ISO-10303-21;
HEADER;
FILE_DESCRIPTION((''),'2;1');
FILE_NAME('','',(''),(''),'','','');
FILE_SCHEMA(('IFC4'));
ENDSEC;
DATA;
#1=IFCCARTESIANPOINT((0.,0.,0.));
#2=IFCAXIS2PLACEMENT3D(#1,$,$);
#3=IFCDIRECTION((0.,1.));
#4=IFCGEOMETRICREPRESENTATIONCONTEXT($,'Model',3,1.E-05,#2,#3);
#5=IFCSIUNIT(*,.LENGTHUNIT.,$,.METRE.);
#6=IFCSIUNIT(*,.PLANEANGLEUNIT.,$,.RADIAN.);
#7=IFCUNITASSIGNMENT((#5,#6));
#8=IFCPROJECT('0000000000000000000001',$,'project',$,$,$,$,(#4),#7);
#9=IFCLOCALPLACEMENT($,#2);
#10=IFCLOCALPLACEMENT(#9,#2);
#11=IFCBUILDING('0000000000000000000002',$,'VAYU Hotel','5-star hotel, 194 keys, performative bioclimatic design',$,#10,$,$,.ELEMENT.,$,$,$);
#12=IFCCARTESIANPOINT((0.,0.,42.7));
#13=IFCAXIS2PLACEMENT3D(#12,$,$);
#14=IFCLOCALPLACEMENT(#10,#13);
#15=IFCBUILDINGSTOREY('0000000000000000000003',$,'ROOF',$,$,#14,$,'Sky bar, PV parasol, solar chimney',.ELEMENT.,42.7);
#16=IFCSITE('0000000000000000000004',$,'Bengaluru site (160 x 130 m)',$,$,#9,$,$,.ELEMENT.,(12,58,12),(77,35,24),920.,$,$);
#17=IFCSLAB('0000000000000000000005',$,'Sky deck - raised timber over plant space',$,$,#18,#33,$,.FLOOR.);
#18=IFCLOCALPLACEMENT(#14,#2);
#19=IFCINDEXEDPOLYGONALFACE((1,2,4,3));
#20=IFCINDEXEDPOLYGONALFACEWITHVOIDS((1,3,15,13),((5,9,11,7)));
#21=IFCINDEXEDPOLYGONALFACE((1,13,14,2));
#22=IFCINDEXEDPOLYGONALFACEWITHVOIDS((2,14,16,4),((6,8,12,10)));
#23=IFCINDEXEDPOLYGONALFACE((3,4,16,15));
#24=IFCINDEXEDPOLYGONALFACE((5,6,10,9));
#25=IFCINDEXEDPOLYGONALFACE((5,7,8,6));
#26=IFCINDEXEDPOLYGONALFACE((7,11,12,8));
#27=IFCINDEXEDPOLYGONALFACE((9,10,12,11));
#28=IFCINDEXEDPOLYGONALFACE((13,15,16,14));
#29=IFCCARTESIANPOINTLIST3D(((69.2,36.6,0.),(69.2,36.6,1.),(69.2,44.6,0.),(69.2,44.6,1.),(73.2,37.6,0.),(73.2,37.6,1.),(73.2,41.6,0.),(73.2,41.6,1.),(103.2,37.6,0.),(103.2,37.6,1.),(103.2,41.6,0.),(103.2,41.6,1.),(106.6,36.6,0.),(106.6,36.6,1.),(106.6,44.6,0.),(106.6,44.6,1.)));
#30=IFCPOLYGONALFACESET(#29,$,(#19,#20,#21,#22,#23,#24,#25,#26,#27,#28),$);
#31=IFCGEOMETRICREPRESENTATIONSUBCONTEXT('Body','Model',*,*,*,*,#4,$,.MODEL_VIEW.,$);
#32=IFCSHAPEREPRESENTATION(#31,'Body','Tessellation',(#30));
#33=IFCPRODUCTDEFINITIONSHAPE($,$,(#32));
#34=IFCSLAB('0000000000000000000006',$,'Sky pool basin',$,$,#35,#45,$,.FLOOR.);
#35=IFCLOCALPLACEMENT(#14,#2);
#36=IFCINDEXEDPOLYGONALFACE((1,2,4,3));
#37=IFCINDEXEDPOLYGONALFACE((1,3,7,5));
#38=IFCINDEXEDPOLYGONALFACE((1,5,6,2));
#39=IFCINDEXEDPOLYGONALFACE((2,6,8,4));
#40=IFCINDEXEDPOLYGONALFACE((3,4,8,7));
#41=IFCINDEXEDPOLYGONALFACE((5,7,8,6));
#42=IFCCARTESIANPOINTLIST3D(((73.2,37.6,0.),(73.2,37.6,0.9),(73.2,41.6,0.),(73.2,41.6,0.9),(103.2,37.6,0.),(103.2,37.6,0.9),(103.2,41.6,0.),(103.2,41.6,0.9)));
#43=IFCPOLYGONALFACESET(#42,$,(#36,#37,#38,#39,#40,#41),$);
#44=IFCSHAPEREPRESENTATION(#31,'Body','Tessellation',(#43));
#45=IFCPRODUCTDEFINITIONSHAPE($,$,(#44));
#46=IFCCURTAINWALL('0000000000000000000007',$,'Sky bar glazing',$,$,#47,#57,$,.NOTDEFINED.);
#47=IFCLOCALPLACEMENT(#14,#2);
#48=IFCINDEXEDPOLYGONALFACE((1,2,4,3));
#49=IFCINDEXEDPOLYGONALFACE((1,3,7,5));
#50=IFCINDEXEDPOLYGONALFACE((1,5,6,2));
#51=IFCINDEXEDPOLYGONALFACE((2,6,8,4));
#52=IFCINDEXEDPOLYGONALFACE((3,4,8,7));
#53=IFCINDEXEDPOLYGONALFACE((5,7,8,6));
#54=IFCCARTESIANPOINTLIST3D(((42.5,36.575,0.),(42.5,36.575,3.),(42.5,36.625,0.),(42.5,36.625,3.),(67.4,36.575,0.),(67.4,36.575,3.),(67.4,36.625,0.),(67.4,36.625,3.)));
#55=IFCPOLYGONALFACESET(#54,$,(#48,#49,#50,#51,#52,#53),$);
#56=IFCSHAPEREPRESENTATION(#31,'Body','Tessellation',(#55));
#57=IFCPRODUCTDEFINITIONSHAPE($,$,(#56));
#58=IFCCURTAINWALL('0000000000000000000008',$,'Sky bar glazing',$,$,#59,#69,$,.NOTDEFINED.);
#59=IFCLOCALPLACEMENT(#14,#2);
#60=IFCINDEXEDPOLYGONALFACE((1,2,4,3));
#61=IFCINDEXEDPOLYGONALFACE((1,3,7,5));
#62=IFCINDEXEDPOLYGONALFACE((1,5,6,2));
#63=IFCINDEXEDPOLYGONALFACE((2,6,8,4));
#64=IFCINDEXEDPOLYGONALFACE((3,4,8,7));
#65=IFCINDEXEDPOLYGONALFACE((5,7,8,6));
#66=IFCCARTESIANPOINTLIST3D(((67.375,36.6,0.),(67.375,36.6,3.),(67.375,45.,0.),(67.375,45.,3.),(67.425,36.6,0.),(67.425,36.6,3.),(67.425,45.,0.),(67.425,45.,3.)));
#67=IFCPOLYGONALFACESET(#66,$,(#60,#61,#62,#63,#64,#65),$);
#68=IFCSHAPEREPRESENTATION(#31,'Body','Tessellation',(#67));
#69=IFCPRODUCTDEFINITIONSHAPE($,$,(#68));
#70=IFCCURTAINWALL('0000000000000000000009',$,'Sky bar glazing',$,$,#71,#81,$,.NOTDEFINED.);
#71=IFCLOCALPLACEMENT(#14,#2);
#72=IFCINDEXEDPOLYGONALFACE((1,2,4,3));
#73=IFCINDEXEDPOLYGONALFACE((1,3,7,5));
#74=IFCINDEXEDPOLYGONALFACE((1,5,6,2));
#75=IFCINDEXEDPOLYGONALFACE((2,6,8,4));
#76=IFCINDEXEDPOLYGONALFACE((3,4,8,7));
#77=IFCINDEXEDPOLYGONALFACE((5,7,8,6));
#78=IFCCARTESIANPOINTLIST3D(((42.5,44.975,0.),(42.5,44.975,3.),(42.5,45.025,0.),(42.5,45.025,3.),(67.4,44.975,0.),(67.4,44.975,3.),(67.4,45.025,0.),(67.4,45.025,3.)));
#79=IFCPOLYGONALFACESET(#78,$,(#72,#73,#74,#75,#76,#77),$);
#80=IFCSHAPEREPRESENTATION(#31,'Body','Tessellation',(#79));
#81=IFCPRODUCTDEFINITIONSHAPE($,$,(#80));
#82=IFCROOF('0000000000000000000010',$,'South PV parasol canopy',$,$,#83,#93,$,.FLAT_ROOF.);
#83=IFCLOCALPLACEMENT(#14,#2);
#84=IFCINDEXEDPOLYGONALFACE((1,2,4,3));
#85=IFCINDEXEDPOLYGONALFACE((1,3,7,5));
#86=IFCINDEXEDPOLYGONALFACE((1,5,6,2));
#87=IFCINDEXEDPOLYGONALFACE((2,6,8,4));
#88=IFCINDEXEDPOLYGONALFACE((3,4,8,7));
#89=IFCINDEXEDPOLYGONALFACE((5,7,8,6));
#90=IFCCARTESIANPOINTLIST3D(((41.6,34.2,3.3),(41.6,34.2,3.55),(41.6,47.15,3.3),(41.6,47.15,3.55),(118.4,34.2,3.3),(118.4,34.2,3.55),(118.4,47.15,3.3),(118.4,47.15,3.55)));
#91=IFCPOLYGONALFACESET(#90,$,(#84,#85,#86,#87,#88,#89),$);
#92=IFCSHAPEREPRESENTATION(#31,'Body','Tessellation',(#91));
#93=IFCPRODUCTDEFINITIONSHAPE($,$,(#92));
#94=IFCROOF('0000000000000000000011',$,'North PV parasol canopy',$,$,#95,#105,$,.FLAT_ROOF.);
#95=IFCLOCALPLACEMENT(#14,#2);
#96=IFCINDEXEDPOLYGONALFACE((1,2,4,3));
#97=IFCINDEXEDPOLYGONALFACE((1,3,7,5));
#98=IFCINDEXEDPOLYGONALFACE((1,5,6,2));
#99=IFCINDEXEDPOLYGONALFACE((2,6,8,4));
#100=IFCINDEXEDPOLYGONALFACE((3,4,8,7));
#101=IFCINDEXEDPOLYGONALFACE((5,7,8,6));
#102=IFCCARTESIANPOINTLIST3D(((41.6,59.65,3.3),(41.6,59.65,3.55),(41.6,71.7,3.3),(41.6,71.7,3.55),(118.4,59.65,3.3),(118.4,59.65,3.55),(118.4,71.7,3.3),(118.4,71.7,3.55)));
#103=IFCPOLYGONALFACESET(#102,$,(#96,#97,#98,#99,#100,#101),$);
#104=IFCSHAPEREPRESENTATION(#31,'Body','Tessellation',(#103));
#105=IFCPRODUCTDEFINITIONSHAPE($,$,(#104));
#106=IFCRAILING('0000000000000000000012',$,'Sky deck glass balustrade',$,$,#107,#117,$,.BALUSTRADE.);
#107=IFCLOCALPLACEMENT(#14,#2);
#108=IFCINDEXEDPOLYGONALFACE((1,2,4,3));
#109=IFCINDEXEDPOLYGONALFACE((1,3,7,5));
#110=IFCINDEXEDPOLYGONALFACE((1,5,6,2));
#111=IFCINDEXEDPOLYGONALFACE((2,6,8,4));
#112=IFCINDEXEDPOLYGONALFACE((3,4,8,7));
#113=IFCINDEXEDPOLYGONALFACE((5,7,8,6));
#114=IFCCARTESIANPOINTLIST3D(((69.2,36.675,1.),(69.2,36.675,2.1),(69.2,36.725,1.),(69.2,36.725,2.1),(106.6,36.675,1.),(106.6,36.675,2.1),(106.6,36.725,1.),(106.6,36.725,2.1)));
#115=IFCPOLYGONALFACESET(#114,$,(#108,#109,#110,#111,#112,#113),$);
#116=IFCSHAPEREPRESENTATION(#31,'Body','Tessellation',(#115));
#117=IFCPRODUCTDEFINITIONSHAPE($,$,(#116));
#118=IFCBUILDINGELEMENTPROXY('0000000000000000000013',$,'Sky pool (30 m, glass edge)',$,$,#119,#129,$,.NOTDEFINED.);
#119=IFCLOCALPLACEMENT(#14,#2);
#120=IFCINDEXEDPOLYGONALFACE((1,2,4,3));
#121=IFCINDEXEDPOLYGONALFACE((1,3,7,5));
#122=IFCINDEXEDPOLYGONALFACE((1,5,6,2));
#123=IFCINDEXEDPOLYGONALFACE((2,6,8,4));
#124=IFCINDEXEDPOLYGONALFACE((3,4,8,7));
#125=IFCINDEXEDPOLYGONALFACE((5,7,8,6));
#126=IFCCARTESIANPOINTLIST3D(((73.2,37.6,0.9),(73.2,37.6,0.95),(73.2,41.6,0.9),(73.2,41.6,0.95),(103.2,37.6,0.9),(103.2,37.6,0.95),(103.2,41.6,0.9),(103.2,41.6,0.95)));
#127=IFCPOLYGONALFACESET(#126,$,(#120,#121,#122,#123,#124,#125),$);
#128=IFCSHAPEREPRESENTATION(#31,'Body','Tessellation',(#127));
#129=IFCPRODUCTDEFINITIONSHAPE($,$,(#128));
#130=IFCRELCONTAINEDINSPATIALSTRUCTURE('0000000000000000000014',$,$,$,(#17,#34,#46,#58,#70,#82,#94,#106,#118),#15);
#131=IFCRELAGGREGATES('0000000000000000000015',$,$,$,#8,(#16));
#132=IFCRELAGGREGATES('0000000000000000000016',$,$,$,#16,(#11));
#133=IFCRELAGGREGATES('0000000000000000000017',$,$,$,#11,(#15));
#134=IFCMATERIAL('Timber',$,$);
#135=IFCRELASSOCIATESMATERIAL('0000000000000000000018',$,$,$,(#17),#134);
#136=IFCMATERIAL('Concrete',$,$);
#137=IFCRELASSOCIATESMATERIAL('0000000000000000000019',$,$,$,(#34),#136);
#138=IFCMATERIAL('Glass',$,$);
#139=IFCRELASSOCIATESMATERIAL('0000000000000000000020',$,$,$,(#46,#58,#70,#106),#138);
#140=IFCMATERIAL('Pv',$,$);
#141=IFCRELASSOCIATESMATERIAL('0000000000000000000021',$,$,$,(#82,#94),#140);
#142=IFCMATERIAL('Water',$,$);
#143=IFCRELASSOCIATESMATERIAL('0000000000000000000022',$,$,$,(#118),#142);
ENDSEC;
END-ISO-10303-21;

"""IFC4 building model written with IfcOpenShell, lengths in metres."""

from ifc_helpers import new_model, si_unit, direction, frame, origin, place, context, subcontext, project, spatial, polyline, outline, extrude, material, element, save


model = new_model("IFC4")

# Units and contexts
model_context = context("Model", 3, precision=1e-05, world=origin(), true_north=direction((0.0, 1.0)))
body_context = subcontext(model_context, "Body", "Model", "MODEL_VIEW")
ifc_project = project(units=[si_unit("LENGTHUNIT", "METRE"), si_unit("PLANEANGLEUNIT", "RADIAN")], contexts=[model_context])

# Site, building, storey
site_placement = place(None, origin())
site = spatial("IfcSite", under=ifc_project, at=site_placement, Name="Bengaluru site (160 x 130 m)", CompositionType="ELEMENT", RefLatitude=(12, 58, 12), RefLongitude=(77, 35, 24), RefElevation=920.0)
building_placement = place(site_placement, origin())
building = spatial("IfcBuilding", under=site, at=building_placement, Name="VAYU Hotel", Description="5-star hotel, 194 keys, performative bioclimatic design", CompositionType="ELEMENT")
storey_placement = place(building_placement, frame((0.0, 0.0, 42.7)))
storey = spatial("IfcBuildingStorey", under=building, at=storey_placement, Name="ROOF", LongName="Sky bar, PV parasol, solar chimney", CompositionType="ELEMENT", Elevation=42.7)

# Slabs
ifc_material_1 = material(Name="Timber")
slab_1_placement = place(storey_placement, origin())
element("IfcSlab", 1, at=slab_1_placement, inside=storey, material=ifc_material_1, Name="Sky deck - raised timber over plant space", PredefinedType="FLOOR", context=body_context, shape_type="SweptSolid", body=[
    extrude(outline(polyline([(69.2, 36.6), (106.6, 36.6), (106.6, 44.6), (69.2, 44.6), (69.2, 36.6)]), holes=[polyline([(73.2, 37.6), (103.2, 37.6), (103.2, 41.6), (73.2, 41.6), (73.2, 37.6)])]), origin(), (0.0, 0.0, 1.0), 1.0),
])
ifc_material_2 = material(Name="Concrete")
slab_2_placement = place(storey_placement, origin())
element("IfcSlab", 2, at=slab_2_placement, inside=storey, material=ifc_material_2, Name="Sky pool basin", PredefinedType="FLOOR", context=body_context, shape_type="SweptSolid", body=[
    extrude(outline(polyline([(73.2, 37.6), (103.2, 37.6), (103.2, 41.6), (73.2, 41.6), (73.2, 37.6)])), origin(), (0.0, 0.0, 1.0), 0.9),
])

# Curtain walls
ifc_material_3 = material(Name="Glass")
curtain_wall_1_placement = place(storey_placement, origin())
element("IfcCurtainWall", 3, at=curtain_wall_1_placement, inside=storey, material=ifc_material_3, Name="Sky bar glazing", PredefinedType="NOTDEFINED", context=body_context, shape_type="SweptSolid", body=[
    extrude(outline(polyline([(42.5, 36.625), (67.4, 36.625), (67.4, 36.575), (42.5, 36.575), (42.5, 36.625)])), origin(), (0.0, 0.0, 1.0), 3.0),
])
curtain_wall_2_placement = place(storey_placement, origin())
element("IfcCurtainWall", 4, at=curtain_wall_2_placement, inside=storey, material=ifc_material_3, Name="Sky bar glazing", PredefinedType="NOTDEFINED", context=body_context, shape_type="SweptSolid", body=[
    extrude(outline(polyline([(67.375, 36.6), (67.375, 45.0), (67.425, 45.0), (67.425, 36.6), (67.375, 36.6)])), origin(), (0.0, 0.0, 1.0), 3.0),
])
curtain_wall_3_placement = place(storey_placement, origin())
element("IfcCurtainWall", 5, at=curtain_wall_3_placement, inside=storey, material=ifc_material_3, Name="Sky bar glazing", PredefinedType="NOTDEFINED", context=body_context, shape_type="SweptSolid", body=[
    extrude(outline(polyline([(42.5, 45.025), (67.4, 45.025), (67.4, 44.975), (42.5, 44.975), (42.5, 45.025)])), origin(), (0.0, 0.0, 1.0), 3.0),
])

# Roofs
ifc_material_4 = material(Name="Pv")
roof_1_placement = place(storey_placement, origin())
element("IfcRoof", 6, at=roof_1_placement, inside=storey, material=ifc_material_4, Name="South PV parasol canopy", PredefinedType="FLAT_ROOF", context=body_context, shape_type="SweptSolid", body=[
    extrude(outline(polyline([(41.6, 34.2), (118.4, 34.2), (118.4, 47.15), (41.6, 47.15), (41.6, 34.2)])), frame((0.0, 0.0, 3.3)), (0.0, 0.0, 1.0), 0.25),
])
roof_2_placement = place(storey_placement, origin())
element("IfcRoof", 7, at=roof_2_placement, inside=storey, material=ifc_material_4, Name="North PV parasol canopy", PredefinedType="FLAT_ROOF", context=body_context, shape_type="SweptSolid", body=[
    extrude(outline(polyline([(41.6, 59.65), (118.4, 59.65), (118.4, 71.7), (41.6, 71.7), (41.6, 59.65)])), frame((0.0, 0.0, 3.3)), (0.0, 0.0, 1.0), 0.25),
])

# Railing
railing_placement = place(storey_placement, origin())
element("IfcRailing", 8, at=railing_placement, inside=storey, material=ifc_material_3, Name="Sky deck glass balustrade", PredefinedType="BALUSTRADE", context=body_context, shape_type="SweptSolid", body=[
    extrude(outline(polyline([(69.2, 36.725), (106.6, 36.725), (106.6, 36.675), (69.2, 36.675), (69.2, 36.725)])), frame((0.0, 0.0, 1.0)), (0.0, 0.0, 1.0), 1.1),
])

# Building element proxy
ifc_material_5 = material(Name="Water")
proxy_placement = place(storey_placement, origin())
element("IfcBuildingElementProxy", 9, at=proxy_placement, inside=storey, material=ifc_material_5, Name="Sky pool (30 m, glass edge)", PredefinedType="NOTDEFINED", context=body_context, shape_type="SweptSolid", body=[
    extrude(outline(polyline([(73.2, 37.6), (103.2, 37.6), (103.2, 41.6), (73.2, 41.6), (73.2, 37.6)])), frame((0.0, 0.0, 0.9)), (0.0, 0.0, 1.0), 0.05),
])

save(model, "model.ifc")
